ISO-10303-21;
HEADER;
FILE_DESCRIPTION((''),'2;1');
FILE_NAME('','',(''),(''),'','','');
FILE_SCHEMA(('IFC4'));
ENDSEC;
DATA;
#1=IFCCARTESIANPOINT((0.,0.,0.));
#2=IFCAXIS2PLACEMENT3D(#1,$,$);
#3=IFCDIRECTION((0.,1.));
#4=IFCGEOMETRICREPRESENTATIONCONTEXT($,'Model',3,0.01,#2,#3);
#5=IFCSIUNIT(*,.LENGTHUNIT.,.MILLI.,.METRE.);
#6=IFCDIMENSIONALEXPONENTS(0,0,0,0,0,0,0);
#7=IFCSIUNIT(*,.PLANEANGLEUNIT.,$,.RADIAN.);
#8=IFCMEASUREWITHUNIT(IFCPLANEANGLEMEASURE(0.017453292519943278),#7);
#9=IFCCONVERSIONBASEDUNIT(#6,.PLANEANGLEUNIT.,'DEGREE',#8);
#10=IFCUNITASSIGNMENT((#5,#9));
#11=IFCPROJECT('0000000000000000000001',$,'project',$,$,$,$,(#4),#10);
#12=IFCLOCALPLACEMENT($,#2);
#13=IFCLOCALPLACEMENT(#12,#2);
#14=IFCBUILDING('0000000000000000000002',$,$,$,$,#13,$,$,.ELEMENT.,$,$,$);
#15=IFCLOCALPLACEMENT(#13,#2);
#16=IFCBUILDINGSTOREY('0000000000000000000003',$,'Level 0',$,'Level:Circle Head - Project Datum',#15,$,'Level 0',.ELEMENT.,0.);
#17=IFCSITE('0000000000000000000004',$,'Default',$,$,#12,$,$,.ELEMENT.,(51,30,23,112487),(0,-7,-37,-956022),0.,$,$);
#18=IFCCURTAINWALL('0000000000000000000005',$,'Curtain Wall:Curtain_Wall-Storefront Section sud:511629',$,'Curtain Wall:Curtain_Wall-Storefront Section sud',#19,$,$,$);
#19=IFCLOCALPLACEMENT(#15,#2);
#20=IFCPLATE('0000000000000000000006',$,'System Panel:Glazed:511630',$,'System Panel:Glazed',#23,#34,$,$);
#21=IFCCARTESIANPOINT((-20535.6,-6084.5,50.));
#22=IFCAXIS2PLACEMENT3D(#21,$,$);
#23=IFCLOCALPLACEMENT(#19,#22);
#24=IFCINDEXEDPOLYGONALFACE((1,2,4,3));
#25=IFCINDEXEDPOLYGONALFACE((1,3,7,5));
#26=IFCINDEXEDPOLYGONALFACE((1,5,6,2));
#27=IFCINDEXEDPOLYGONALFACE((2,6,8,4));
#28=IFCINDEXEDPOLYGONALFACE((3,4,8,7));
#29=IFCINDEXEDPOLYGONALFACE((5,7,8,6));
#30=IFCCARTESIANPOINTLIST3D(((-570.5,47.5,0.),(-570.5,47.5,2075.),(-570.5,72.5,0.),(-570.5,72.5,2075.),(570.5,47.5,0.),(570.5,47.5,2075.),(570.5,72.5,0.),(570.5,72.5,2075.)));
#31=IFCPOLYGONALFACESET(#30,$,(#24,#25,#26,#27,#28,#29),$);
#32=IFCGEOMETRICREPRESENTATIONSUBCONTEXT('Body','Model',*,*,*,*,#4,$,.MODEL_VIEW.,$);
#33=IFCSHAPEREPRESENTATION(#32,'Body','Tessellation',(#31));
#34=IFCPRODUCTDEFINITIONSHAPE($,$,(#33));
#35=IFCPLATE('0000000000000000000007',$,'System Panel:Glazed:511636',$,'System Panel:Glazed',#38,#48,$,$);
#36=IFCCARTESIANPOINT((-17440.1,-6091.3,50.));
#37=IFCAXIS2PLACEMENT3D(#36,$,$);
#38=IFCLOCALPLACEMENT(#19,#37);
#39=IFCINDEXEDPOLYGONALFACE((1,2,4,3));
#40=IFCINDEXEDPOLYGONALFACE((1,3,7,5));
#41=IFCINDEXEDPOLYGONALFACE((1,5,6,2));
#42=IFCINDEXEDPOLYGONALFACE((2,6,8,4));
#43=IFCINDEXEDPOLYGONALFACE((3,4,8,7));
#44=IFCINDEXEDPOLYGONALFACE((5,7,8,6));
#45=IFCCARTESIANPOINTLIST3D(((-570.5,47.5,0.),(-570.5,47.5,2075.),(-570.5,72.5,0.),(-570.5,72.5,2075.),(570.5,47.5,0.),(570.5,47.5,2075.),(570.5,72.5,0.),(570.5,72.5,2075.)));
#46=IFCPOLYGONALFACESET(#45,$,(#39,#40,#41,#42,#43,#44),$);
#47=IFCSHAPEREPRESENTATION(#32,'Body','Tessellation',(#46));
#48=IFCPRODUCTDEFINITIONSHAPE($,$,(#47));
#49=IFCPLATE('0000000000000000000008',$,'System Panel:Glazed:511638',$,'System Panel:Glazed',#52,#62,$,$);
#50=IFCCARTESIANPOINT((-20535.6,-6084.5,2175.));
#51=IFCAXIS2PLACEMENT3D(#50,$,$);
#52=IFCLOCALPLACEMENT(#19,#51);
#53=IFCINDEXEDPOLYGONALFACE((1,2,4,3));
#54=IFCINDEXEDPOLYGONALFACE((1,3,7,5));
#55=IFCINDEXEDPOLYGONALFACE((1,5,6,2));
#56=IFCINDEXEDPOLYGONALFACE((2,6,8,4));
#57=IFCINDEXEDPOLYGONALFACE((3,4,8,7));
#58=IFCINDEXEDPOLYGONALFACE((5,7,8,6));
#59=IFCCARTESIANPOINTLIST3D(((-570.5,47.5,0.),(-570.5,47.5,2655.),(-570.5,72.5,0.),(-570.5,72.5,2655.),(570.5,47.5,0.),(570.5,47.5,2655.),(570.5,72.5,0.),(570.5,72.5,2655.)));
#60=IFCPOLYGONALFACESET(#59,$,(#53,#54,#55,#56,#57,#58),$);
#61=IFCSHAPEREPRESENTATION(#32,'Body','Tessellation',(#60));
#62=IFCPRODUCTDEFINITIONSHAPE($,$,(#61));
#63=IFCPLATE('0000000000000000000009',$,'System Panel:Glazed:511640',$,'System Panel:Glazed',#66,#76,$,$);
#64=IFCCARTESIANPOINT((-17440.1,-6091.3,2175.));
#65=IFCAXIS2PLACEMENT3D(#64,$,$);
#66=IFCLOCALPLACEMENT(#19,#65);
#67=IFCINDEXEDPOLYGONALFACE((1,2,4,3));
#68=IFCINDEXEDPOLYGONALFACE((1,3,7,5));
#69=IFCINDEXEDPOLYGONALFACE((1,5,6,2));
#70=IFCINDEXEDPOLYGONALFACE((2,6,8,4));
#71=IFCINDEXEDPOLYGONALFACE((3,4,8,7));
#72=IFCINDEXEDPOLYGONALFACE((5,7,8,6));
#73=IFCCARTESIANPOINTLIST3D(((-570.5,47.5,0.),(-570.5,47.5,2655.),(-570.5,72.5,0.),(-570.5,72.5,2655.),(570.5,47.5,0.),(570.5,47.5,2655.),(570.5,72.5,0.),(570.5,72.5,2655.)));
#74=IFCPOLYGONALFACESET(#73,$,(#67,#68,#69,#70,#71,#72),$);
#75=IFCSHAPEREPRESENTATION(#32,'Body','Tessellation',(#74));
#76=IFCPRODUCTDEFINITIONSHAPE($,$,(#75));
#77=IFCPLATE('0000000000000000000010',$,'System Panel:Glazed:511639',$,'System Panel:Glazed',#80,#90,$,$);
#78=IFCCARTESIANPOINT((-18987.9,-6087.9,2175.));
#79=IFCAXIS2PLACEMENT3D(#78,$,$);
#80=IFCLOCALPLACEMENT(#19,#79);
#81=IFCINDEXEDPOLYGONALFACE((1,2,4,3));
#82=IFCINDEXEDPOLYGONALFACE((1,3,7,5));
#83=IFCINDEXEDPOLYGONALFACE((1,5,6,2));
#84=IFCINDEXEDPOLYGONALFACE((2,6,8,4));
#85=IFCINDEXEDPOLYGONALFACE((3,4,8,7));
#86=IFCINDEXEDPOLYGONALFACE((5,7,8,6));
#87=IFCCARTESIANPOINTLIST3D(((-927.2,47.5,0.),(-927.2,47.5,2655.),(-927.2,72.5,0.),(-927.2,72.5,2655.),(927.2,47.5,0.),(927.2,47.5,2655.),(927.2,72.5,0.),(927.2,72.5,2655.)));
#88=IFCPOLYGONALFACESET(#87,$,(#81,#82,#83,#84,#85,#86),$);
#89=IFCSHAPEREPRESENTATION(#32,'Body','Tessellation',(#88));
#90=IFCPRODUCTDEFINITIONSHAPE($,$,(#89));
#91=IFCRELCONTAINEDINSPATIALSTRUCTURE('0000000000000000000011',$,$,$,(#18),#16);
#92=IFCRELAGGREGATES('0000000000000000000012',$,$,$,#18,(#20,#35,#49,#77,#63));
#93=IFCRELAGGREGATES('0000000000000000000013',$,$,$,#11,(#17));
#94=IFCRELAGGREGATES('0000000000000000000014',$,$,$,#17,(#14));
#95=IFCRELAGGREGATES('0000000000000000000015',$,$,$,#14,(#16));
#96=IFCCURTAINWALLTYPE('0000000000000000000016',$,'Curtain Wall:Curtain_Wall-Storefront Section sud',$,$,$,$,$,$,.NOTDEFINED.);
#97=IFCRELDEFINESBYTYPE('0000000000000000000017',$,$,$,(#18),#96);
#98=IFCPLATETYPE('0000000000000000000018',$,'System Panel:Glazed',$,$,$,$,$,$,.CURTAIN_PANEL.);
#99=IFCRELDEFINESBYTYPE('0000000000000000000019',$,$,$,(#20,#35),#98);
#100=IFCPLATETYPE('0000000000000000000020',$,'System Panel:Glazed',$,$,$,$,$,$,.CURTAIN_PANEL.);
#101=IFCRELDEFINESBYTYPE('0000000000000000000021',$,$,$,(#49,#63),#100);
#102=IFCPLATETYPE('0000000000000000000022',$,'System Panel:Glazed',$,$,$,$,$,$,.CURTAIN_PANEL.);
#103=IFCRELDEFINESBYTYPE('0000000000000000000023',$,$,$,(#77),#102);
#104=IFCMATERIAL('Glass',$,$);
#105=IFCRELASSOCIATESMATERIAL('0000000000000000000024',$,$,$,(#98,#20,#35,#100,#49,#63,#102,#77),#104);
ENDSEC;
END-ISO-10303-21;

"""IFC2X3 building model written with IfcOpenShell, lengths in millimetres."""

from ifc_helpers import new_model, entity, si_unit, converted_unit, direction, frame, frame_2d, origin, origin_2d_with_axis, place, context, subcontext, project, spatial, rectangle, extrude, source, transform, mapped, material, type_object, type_shapes, element, aggregate, save


model = new_model("IFC2X3")

# Units and contexts
model_context = context("Model", 3, precision=0.01, world=origin(), true_north=direction((0.0, 1.0)))
body_context = subcontext(model_context, "Body", "Model", "MODEL_VIEW")
ifc_project = project(units=[si_unit("LENGTHUNIT", "METRE", prefix="MILLI"), converted_unit("PLANEANGLEUNIT", "DEGREE", entity("IfcPlaneAngleMeasure", 0.017453292519943278), si_unit("PLANEANGLEUNIT", "RADIAN"), dimensions=[0, 0, 0, 0, 0, 0, 0])], contexts=[model_context])

# Site, building, storey
site_placement = place(None, origin())
site = spatial("IfcSite", under=ifc_project, at=site_placement, Name="Default", CompositionType="ELEMENT", RefLatitude=(51, 30, 23, 112487), RefLongitude=(0, -7, -37, -956022), RefElevation=0.0)
building_placement = place(site_placement, origin())
building = spatial("IfcBuilding", under=site, at=building_placement, CompositionType="ELEMENT")
storey_placement = place(building_placement, origin())
storey = spatial("IfcBuildingStorey", under=building, at=storey_placement, Name="Level 0", ObjectType="Level:Circle Head - Project Datum", LongName="Level 0", CompositionType="ELEMENT", Elevation=0.0)

# Curtain wall
curtain_wall_type_1 = type_object("IfcCurtainWallType", Name="Curtain Wall:Curtain_Wall-Storefront Section sud", PredefinedType="NOTDEFINED")
curtain_wall_1_placement = place(storey_placement, origin())
curtain_wall_1 = element("IfcCurtainWall", 1, at=curtain_wall_1_placement, inside=storey, type_object=curtain_wall_type_1, Name="Curtain Wall:Curtain_Wall-Storefront Section sud:511629", ObjectType="Curtain Wall:Curtain_Wall-Storefront Section sud")

# Plates
ifc_material_1 = material(Name="Glass")
plate_type_1 = type_object("IfcPlateType", Name="System Panel:Glazed", PredefinedType="CURTAIN_PANEL", material=ifc_material_1)
shared_shape_1 = source(origin(), body_context, "Body", "SweptSolid", [
    extrude(rectangle(XDim=25.0, YDim=1141.0, at=origin_2d_with_axis()), frame((0.0, 60.0, 0.0), z_axis=(0.0, 0.0, 1.0), x_axis=(0.0, 1.0, 0.0)), (0.0, 0.0, 1.0), 2075.0),
])
type_shapes(plate_type_1, [shared_shape_1])
plate_1_placement = place(curtain_wall_1_placement, frame((-20535.6, -6084.5, 50.0)))
plate_1 = element("IfcPlate", 2, at=plate_1_placement, type_object=plate_type_1, material=ifc_material_1, Name="System Panel:Glazed:511630", ObjectType="System Panel:Glazed", context=body_context, shape_type="MappedRepresentation", body=[
    mapped(shared_shape_1, transform((0.0, 0.0, 0.0), scale=1.0)),
])
plate_2_placement = place(curtain_wall_1_placement, frame((-17440.1, -6091.3, 50.0)))
plate_2 = element("IfcPlate", 3, at=plate_2_placement, type_object=plate_type_1, material=ifc_material_1, Name="System Panel:Glazed:511636", ObjectType="System Panel:Glazed", context=body_context, shape_type="MappedRepresentation", body=[
    mapped(shared_shape_1, transform((0.0, 0.0, 0.0), scale=1.0)),
])
plate_type_2 = type_object("IfcPlateType", Name="System Panel:Glazed", PredefinedType="CURTAIN_PANEL", material=ifc_material_1)
shared_shape_2 = source(origin(), body_context, "Body", "SweptSolid", [
    extrude(rectangle(XDim=25.0, YDim=1141.0, at=frame_2d((0.0, 0.0), x_axis=(1.0, 0.0))), frame((0.0, 60.0, 0.0), z_axis=(0.0, 0.0, 1.0), x_axis=(0.0, 1.0, 0.0)), (0.0, 0.0, 1.0), 2655.0),
])
type_shapes(plate_type_2, [shared_shape_2])
plate_3_placement = place(curtain_wall_1_placement, frame((-20535.6, -6084.5, 2175.0)))
plate_3 = element("IfcPlate", 4, at=plate_3_placement, type_object=plate_type_2, material=ifc_material_1, Name="System Panel:Glazed:511638", ObjectType="System Panel:Glazed", context=body_context, shape_type="MappedRepresentation", body=[
    mapped(shared_shape_2, transform((0.0, 0.0, 0.0), scale=1.0)),
])
plate_4_placement = place(curtain_wall_1_placement, frame((-17440.1, -6091.3, 2175.0)))
plate_4 = element("IfcPlate", 5, at=plate_4_placement, type_object=plate_type_2, material=ifc_material_1, Name="System Panel:Glazed:511640", ObjectType="System Panel:Glazed", context=body_context, shape_type="MappedRepresentation", body=[
    mapped(shared_shape_2, transform((0.0, 0.0, 0.0), scale=1.0)),
])
plate_type_3 = type_object("IfcPlateType", Name="System Panel:Glazed", PredefinedType="CURTAIN_PANEL", material=ifc_material_1)
shared_shape_3 = source(origin(), body_context, "Body", "SweptSolid", [
    extrude(rectangle(XDim=25.0, YDim=1854.5, at=frame_2d((0.0, 0.0), x_axis=(1.0, 0.0))), frame((0.0, 60.0, 0.0), z_axis=(0.0, 0.0, 1.0), x_axis=(0.0, 1.0, 0.0)), (0.0, 0.0, 1.0), 2655.0),
])
type_shapes(plate_type_3, [shared_shape_3])
plate_5_placement = place(curtain_wall_1_placement, frame((-18987.9, -6087.9, 2175.0)))
plate_5 = element("IfcPlate", 6, at=plate_5_placement, type_object=plate_type_3, material=ifc_material_1, Name="System Panel:Glazed:511639", ObjectType="System Panel:Glazed", context=body_context, shape_type="MappedRepresentation", body=[
    mapped(shared_shape_3, transform((0.0, 0.0, 0.0), scale=1.0)),
])
aggregate(curtain_wall_1, [plate_1, plate_2, plate_3, plate_5, plate_4])

save(model, "model.ifc")
